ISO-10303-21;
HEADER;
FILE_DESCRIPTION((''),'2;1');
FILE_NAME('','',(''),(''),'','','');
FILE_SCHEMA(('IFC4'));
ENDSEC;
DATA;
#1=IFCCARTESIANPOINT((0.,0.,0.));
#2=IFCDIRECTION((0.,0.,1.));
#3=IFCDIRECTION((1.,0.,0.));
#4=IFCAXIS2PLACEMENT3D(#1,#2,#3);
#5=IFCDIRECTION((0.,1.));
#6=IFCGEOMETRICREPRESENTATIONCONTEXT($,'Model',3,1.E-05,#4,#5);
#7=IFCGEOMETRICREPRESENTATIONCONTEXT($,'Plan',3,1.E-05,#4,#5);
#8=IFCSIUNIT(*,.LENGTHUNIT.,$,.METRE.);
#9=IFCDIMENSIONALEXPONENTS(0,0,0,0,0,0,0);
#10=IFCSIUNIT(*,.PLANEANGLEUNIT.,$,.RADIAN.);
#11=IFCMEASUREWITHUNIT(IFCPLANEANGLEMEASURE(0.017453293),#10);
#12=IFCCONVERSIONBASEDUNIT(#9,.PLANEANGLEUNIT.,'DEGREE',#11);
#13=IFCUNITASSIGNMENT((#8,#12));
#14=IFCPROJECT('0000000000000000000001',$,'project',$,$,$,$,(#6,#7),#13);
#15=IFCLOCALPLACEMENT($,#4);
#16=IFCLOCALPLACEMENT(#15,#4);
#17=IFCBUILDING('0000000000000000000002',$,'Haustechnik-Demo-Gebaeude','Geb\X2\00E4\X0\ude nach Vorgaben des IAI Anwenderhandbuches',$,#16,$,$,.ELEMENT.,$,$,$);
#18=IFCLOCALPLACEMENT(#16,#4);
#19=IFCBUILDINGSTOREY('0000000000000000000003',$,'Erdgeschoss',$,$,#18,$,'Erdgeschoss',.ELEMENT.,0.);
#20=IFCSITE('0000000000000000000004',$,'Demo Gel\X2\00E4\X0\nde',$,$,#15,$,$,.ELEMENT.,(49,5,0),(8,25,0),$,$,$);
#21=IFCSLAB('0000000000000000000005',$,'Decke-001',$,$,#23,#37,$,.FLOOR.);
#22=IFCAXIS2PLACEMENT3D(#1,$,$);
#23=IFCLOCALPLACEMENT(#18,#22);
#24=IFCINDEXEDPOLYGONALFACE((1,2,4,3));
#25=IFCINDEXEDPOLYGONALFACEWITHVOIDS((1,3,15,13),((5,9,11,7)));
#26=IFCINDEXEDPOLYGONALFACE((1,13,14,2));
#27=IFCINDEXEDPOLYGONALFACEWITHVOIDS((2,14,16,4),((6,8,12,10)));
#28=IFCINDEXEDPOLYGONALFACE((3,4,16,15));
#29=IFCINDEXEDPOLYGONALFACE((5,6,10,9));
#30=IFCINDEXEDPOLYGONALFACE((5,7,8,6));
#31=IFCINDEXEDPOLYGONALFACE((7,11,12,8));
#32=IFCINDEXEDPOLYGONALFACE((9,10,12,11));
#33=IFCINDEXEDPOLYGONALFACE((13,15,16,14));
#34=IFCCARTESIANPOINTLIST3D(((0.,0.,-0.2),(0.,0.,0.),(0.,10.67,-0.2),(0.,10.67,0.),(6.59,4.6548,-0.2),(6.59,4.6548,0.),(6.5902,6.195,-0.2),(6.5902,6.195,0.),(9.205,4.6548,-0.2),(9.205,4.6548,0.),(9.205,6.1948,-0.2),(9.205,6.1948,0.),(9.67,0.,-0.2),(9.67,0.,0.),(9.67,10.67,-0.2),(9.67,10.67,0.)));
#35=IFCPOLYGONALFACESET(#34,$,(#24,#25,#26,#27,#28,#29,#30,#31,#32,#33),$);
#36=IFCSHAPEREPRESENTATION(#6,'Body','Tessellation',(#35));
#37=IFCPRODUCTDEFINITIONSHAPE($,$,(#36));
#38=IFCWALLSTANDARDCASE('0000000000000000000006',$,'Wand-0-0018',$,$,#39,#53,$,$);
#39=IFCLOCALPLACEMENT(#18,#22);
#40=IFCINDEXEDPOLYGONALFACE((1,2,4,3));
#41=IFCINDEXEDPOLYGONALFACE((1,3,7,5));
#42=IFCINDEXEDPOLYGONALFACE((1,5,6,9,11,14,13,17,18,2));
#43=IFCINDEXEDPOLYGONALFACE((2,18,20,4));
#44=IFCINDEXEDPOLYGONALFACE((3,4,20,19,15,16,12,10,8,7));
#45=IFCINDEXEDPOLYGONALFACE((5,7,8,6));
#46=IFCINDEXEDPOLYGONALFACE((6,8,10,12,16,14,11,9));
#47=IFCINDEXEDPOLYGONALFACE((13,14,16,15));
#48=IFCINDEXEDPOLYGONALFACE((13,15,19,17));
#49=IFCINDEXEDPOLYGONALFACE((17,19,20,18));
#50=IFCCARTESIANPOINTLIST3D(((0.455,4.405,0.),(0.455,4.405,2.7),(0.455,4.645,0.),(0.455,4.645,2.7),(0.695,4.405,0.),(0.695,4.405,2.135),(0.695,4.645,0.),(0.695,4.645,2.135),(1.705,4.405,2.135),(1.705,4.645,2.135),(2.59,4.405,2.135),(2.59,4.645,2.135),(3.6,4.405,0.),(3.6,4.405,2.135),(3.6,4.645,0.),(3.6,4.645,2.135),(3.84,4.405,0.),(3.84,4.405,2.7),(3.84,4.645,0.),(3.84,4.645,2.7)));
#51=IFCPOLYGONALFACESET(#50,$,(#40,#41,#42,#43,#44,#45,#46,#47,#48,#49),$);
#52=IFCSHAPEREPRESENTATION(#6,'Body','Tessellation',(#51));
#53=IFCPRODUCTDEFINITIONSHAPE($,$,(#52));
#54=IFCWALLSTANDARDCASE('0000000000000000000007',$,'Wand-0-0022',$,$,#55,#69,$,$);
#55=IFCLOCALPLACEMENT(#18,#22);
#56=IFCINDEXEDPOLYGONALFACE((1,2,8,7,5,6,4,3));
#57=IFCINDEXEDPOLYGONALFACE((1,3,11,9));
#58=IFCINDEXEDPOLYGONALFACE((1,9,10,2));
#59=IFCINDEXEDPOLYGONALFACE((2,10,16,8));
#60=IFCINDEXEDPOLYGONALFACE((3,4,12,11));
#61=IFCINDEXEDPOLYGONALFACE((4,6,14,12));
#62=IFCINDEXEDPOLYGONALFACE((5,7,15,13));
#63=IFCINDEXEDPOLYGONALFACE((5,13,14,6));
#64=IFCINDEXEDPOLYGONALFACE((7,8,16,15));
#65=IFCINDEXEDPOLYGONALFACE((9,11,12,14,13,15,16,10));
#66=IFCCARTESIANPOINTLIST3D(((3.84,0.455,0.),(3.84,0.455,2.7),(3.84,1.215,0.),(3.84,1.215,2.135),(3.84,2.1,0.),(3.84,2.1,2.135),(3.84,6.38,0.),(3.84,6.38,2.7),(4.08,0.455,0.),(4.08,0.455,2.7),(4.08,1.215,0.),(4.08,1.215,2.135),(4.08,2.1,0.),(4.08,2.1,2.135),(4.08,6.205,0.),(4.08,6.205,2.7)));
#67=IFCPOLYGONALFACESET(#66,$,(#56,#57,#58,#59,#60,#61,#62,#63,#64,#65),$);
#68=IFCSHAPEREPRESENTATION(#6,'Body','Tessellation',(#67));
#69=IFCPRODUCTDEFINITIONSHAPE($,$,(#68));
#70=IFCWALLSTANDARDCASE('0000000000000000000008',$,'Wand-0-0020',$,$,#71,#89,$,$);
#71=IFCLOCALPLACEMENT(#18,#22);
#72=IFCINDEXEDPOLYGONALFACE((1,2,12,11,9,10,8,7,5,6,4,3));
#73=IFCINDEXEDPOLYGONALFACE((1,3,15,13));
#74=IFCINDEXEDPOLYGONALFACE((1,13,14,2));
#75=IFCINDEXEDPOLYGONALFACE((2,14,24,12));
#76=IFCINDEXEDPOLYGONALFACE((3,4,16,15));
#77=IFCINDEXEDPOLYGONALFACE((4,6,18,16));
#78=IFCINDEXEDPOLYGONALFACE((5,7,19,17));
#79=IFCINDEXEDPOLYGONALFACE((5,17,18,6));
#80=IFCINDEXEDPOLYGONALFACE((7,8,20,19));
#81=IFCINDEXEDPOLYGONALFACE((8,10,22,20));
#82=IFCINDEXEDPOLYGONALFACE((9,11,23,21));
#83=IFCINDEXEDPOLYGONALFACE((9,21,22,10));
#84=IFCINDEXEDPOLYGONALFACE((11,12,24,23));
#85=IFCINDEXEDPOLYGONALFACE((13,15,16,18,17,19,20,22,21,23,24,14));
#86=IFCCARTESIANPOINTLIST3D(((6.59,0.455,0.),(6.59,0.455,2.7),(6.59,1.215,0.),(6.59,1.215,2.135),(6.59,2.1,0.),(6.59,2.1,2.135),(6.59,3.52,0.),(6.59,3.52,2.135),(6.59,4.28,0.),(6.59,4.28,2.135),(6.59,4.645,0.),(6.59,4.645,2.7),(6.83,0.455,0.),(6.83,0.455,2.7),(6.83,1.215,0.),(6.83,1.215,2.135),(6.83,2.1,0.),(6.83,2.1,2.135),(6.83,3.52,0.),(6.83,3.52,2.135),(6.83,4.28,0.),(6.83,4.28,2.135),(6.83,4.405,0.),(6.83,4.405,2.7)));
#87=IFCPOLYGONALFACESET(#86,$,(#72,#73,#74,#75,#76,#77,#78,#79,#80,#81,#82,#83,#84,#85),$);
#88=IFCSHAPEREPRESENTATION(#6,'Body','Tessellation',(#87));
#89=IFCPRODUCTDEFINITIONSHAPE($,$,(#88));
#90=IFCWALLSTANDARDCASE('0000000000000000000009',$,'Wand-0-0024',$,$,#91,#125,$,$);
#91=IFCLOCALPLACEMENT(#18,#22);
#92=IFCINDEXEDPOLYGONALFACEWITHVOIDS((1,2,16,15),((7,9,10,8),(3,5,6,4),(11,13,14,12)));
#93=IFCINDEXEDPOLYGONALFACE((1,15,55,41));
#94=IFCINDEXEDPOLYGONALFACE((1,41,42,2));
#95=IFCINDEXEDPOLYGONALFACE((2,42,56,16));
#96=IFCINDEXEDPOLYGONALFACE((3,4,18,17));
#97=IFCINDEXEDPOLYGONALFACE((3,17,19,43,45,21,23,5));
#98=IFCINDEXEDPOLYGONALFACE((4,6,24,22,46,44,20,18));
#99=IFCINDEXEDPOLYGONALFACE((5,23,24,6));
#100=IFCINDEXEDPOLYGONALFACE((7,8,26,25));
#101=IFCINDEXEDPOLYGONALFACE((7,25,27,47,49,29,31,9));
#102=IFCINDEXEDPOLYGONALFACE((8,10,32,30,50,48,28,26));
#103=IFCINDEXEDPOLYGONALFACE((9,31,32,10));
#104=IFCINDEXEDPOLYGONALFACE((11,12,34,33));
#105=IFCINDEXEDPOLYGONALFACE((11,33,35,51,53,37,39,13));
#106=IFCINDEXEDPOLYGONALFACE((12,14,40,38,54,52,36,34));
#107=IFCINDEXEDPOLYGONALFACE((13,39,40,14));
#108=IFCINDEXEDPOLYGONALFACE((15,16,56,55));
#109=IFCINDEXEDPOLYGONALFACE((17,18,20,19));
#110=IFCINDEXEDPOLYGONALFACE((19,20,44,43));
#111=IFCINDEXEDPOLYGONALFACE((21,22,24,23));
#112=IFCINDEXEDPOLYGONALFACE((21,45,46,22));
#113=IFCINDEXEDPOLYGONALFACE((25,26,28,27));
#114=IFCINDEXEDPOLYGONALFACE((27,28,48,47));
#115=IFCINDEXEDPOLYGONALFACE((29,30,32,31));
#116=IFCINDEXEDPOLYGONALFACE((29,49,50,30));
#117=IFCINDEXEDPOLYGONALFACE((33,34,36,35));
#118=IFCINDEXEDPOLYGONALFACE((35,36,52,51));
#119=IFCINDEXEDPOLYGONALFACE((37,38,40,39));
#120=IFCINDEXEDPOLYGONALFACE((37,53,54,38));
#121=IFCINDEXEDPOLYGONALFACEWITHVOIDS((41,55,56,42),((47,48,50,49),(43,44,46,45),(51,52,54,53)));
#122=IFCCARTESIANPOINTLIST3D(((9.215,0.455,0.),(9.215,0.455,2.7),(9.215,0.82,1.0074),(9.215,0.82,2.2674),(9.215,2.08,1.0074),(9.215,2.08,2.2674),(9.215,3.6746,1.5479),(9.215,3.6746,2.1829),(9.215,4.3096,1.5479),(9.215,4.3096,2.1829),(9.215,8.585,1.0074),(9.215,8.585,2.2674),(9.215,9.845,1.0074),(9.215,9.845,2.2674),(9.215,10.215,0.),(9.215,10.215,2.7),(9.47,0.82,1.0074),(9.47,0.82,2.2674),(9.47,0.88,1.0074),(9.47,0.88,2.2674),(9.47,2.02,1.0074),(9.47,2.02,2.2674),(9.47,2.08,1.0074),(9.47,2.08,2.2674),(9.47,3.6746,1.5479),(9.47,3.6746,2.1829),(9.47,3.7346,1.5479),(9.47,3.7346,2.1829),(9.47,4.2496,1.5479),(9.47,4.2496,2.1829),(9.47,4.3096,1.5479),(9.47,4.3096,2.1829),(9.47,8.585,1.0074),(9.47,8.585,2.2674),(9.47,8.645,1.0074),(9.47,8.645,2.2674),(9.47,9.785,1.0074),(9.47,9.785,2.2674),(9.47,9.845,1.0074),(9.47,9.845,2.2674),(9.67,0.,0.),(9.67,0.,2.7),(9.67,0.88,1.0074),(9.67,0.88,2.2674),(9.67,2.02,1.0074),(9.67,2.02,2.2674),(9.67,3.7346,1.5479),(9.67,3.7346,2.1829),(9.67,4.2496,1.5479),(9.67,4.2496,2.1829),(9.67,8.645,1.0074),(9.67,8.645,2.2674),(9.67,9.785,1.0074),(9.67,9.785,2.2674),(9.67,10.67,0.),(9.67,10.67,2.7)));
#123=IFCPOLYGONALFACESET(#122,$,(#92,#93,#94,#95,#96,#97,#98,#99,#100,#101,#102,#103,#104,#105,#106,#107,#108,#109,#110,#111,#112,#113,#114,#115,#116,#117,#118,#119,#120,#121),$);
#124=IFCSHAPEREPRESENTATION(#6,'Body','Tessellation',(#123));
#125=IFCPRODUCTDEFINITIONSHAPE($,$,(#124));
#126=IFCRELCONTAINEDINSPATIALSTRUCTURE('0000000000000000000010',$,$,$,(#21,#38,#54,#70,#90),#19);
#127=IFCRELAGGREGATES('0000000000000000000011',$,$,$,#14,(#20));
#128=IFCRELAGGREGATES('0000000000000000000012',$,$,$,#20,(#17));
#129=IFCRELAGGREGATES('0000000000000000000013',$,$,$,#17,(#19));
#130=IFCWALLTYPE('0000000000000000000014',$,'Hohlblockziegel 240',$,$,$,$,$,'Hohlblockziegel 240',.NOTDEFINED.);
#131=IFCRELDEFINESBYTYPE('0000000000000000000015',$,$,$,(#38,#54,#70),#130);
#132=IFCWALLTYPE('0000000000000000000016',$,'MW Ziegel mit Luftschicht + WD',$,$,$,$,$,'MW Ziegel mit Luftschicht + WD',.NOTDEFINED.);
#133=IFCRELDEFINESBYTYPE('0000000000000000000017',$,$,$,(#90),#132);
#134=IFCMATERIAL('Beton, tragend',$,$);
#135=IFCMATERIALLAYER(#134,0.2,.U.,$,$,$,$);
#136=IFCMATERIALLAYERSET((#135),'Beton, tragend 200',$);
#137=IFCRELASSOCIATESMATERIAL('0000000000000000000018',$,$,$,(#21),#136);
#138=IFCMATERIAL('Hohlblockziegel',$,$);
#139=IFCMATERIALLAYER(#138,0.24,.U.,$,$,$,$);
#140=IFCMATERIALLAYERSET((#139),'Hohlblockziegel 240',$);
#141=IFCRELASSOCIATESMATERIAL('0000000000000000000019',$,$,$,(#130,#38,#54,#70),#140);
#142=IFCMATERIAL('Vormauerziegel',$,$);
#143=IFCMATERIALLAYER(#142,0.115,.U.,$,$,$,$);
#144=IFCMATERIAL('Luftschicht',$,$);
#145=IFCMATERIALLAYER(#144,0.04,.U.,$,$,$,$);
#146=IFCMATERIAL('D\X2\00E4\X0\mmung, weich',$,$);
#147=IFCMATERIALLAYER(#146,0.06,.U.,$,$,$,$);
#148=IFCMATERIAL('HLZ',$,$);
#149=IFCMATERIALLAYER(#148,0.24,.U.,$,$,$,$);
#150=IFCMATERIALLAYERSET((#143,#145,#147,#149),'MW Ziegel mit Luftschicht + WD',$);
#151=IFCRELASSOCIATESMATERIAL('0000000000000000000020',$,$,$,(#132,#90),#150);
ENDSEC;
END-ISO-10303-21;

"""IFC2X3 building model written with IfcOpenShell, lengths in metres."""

from ifc_helpers import new_model, entity, si_unit, converted_unit, direction, frame, frame_2d, origin_with_axes, place, context, project, spatial, polyline, rectangle, outline, extrude, material, layer, layer_set, layer_usage, type_object, element, save


model = new_model("IFC2X3")

# Units and contexts
model_context = context("Model", 3, precision=1e-05, world=origin_with_axes(), true_north=direction((0.0, 1.0)))
plan_context = context("Plan", 3, precision=1e-05, world=origin_with_axes(), true_north=direction((0.0, 1.0)))
ifc_project = project(units=[si_unit("LENGTHUNIT", "METRE"), converted_unit("PLANEANGLEUNIT", "DEGREE", entity("IfcPlaneAngleMeasure", 0.017453293), si_unit("PLANEANGLEUNIT", "RADIAN"), dimensions=[0, 0, 0, 0, 0, 0, 0])], contexts=[model_context, plan_context])

# Site, building, storey
site_placement = place(None, origin_with_axes())
site = spatial("IfcSite", under=ifc_project, at=site_placement, Name="Demo Gelände", CompositionType="ELEMENT", RefLatitude=(49, 5, 0), RefLongitude=(8, 25, 0))
building_placement = place(site_placement, origin_with_axes())
building = spatial("IfcBuilding", under=site, at=building_placement, Name="Haustechnik-Demo-Gebaeude", Description="Gebäude nach Vorgaben des IAI Anwenderhandbuches", CompositionType="ELEMENT")
storey_placement = place(building_placement, origin_with_axes())
storey = spatial("IfcBuildingStorey", under=building, at=storey_placement, Name="Erdgeschoss", LongName="Erdgeschoss", CompositionType="ELEMENT", Elevation=0.0)

# Slab, opening
ifc_material_1 = material(Name="Beton, tragend")
ifc_layer_1 = layer(ifc_material_1, 0.2, ventilated="UNKNOWN")
ifc_layer_set_1 = layer_set([ifc_layer_1], Name="Beton, tragend 200")
ifc_layer_usage_1 = layer_usage(ifc_layer_set_1, "AXIS3", "NEGATIVE", 0.2)
slab_placement = place(storey_placement, frame((9.67, 10.67, -0.2), z_axis=(0.0, 0.0, 1.0), x_axis=(-1.0, 0.0, 0.0)))
slab = element("IfcSlab", 1, at=slab_placement, inside=storey, material=ifc_layer_usage_1, Name="Decke-001", PredefinedType="FLOOR", context=model_context, shape_type="SweptSolid", body=[
    extrude(outline(polyline([(0.0, 0.0), (9.67, 0.0), (9.67, 10.67), (0.0, 10.67), (0.0, 0.0)])), origin_with_axes(), (0.0, 0.0, 1.0), 0.2),
])
opening_1_placement = place(slab_placement, origin_with_axes())
element("IfcOpeningElement", 2, at=opening_1_placement, cuts=slab, context=model_context, shape_type="SweptSolid", body=[
    extrude(outline(polyline([(0.465, 6.0152), (3.08, 6.0152), (3.0798, 4.475), (0.465, 4.4752), (0.465, 6.0152)])), origin_with_axes(), (0.0, 0.0, 1.0), 0.2),
])

# Wall, openings
ifc_material_2 = material(Name="Hohlblockziegel")
ifc_layer_2 = layer(ifc_material_2, 0.24, ventilated="UNKNOWN")
ifc_layer_set_2 = layer_set([ifc_layer_2], Name="Hohlblockziegel 240")
ifc_layer_usage_2 = layer_usage(ifc_layer_set_2, "AXIS2", "NEGATIVE", 0.0)
wall_type_1 = type_object("IfcWallType", Name="Hohlblockziegel 240", ElementType="Hohlblockziegel 240", PredefinedType="NOTDEFINED", material=ifc_layer_set_2)
wall_1_placement = place(storey_placement, frame((0.0, 4.645, 0.0), z_axis=(0.0, 0.0, 1.0), x_axis=(1.0, 0.0, 0.0)))
wall_1 = element("IfcWallStandardCase", 3, at=wall_1_placement, inside=storey, type_object=wall_type_1, material=ifc_layer_usage_2, Name="Wand-0-0018", context=model_context, shape_type="SweptSolid", body=[
    extrude(outline(polyline([(0.455, -0.24), (3.84, -0.24), (3.84, 0.0), (0.455, 0.0), (0.455, -0.24)])), origin_with_axes(), (0.0, 0.0, 1.0), 2.7),
])
opening_2_placement = place(wall_1_placement, frame((2.1475, -0.24, 0.0), z_axis=(0.0, 0.0, 1.0), x_axis=(1.0, 0.0, 0.0)))
element("IfcOpeningElement", 4, at=opening_2_placement, cuts=wall_1, ObjectType="Opening", context=model_context, shape_type="SweptSolid", body=[
    extrude(outline(polyline([(-0.4425, 0.0), (0.4425, 0.0), (0.4425, 2.135), (-0.4425, 2.135), (-0.4425, 0.0)])), frame((0.0, 0.0, 0.0), z_axis=(0.0, 1.0, 0.0), x_axis=(-1.0, 0.0, 0.0)), (0.0, 0.0, 1.0), 0.24),
])
opening_3_placement = place(wall_1_placement, frame((1.2, -0.24, 0.0), z_axis=(0.0, 0.0, 1.0), x_axis=(1.0, 0.0, 0.0)))
element("IfcOpeningElement", 5, at=opening_3_placement, cuts=wall_1, ObjectType="Opening", context=model_context, shape_type="SweptSolid", body=[
    extrude(outline(polyline([(-0.505, 0.0), (0.505, 0.0), (0.505, 2.135), (-0.505, 2.135), (-0.505, 0.0)])), frame((0.0, 0.0, 0.0), z_axis=(0.0, 1.0, 0.0), x_axis=(-1.0, 0.0, 0.0)), (0.0, 0.0, 1.0), 0.24),
])
opening_4_placement = place(wall_1_placement, frame((3.095, -0.24, 0.0), z_axis=(0.0, 0.0, 1.0), x_axis=(1.0, 0.0, 0.0)))
element("IfcOpeningElement", 6, at=opening_4_placement, cuts=wall_1, ObjectType="Opening", context=model_context, shape_type="SweptSolid", body=[
    extrude(outline(polyline([(-0.505, 0.0), (0.505, 0.0), (0.505, 2.135), (-0.505, 2.135), (-0.505, 0.0)])), frame((0.0, 0.0, 0.0), z_axis=(0.0, 1.0, 0.0), x_axis=(-1.0, 0.0, 0.0)), (0.0, 0.0, 1.0), 0.24),
])

# Wall, opening
ifc_layer_usage_3 = layer_usage(ifc_layer_set_2, "AXIS2", "NEGATIVE", 0.0)
wall_2_placement = place(storey_placement, frame((3.84, 0.0, 0.0), z_axis=(0.0, 0.0, 1.0), x_axis=(0.0, 1.0, 0.0)))
wall_2 = element("IfcWallStandardCase", 7, at=wall_2_placement, inside=storey, type_object=wall_type_1, material=ifc_layer_usage_3, Name="Wand-0-0022", context=model_context, shape_type="SweptSolid", body=[
    extrude(outline(polyline([(0.455, -0.24), (6.205, -0.24), (6.38, 0.0), (0.455, 0.0), (0.455, -0.24)])), origin_with_axes(), (0.0, 0.0, 1.0), 2.7),
])
opening_5_placement = place(wall_2_placement, frame((1.6575, -0.24, 0.0), z_axis=(0.0, 0.0, 1.0), x_axis=(1.0, 0.0, 0.0)))
element("IfcOpeningElement", 8, at=opening_5_placement, cuts=wall_2, ObjectType="Opening", context=model_context, shape_type="SweptSolid", body=[
    extrude(rectangle(XDim=0.885, YDim=2.135, at=frame_2d((0.0, 1.0675), x_axis=(-1.0, 0.0))), frame((0.0, 0.0, 0.0), z_axis=(0.0, 1.0, 0.0), x_axis=(-1.0, 0.0, 0.0)), (0.0, 0.0, 1.0), 0.24),
])

# Wall, openings
ifc_layer_usage_4 = layer_usage(ifc_layer_set_2, "AXIS2", "POSITIVE", 0.0)
wall_3_placement = place(storey_placement, frame((6.83, 0.0, 0.0), z_axis=(0.0, 0.0, 1.0), x_axis=(0.0, 1.0, 0.0)))
wall_3 = element("IfcWallStandardCase", 9, at=wall_3_placement, inside=storey, type_object=wall_type_1, material=ifc_layer_usage_4, Name="Wand-0-0020", context=model_context, shape_type="SweptSolid", body=[
    extrude(outline(polyline([(0.455, 0.0), (4.405, 0.0), (4.645, 0.24), (0.455, 0.24), (0.455, 0.0)])), origin_with_axes(), (0.0, 0.0, 1.0), 2.7),
])
opening_6_placement = place(wall_3_placement, frame((3.9, 0.0, 0.0), z_axis=(0.0, 0.0, 1.0), x_axis=(1.0, 0.0, 0.0)))
element("IfcOpeningElement", 10, at=opening_6_placement, cuts=wall_3, ObjectType="Opening", context=model_context, shape_type="SweptSolid", body=[
    extrude(rectangle(XDim=0.76, YDim=2.135, at=frame_2d((0.0, 1.0675), x_axis=(-1.0, 0.0))), frame((0.0, 0.0, 0.0), z_axis=(0.0, 1.0, 0.0), x_axis=(-1.0, 0.0, 0.0)), (0.0, 0.0, 1.0), 0.24),
])
opening_7_placement = place(wall_3_placement, frame((1.6575, 0.0, 0.0), z_axis=(0.0, 0.0, 1.0), x_axis=(1.0, 0.0, 0.0)))
element("IfcOpeningElement", 11, at=opening_7_placement, cuts=wall_3, ObjectType="Opening", context=model_context, shape_type="SweptSolid", body=[
    extrude(rectangle(XDim=0.885, YDim=2.135, at=frame_2d((0.0, 1.0675), x_axis=(-1.0, 0.0))), frame((0.0, 0.0, 0.0), z_axis=(0.0, 1.0, 0.0), x_axis=(-1.0, 0.0, 0.0)), (0.0, 0.0, 1.0), 0.24),
])

# Wall, openings
ifc_material_3 = material(Name="Vormauerziegel")
ifc_layer_3 = layer(ifc_material_3, 0.115, ventilated="UNKNOWN")
ifc_material_4 = material(Name="Luftschicht")
ifc_layer_4 = layer(ifc_material_4, 0.04, ventilated="UNKNOWN")
ifc_material_5 = material(Name="Dämmung, weich")
ifc_layer_5 = layer(ifc_material_5, 0.06, ventilated="UNKNOWN")
ifc_material_6 = material(Name="HLZ")
ifc_layer_6 = layer(ifc_material_6, 0.24, ventilated="UNKNOWN")
ifc_layer_set_3 = layer_set([ifc_layer_3, ifc_layer_4, ifc_layer_5, ifc_layer_6], Name="MW Ziegel mit Luftschicht + WD")
ifc_layer_usage_5 = layer_usage(ifc_layer_set_3, "AXIS2", "POSITIVE", 0.0)
wall_type_2 = type_object("IfcWallType", Name="MW Ziegel mit Luftschicht + WD", ElementType="MW Ziegel mit Luftschicht + WD", PredefinedType="NOTDEFINED", material=ifc_layer_set_3)
wall_4_placement = place(storey_placement, frame((9.67, 0.0, 0.0), z_axis=(0.0, 0.0, 1.0), x_axis=(0.0, 1.0, 0.0)))
wall_4 = element("IfcWallStandardCase", 12, at=wall_4_placement, inside=storey, type_object=wall_type_2, material=ifc_layer_usage_5, Name="Wand-0-0024", context=model_context, shape_type="SweptSolid", body=[
    extrude(outline(polyline([(0.0, 0.0), (10.67, 0.0), (10.215, 0.455), (0.455, 0.455), (0.0, 0.0)])), origin_with_axes(), (0.0, 0.0, 1.0), 2.7),
])
opening_8_placement = place(wall_4_placement, frame((3.9921, 0.0, 1.5479), z_axis=(0.0, 0.0, 1.0), x_axis=(1.0, 0.0, 0.0)))
element("IfcOpeningElement", 13, at=opening_8_placement, cuts=wall_4, ObjectType="Opening", context=model_context, shape_type="SweptSolid", body=[
    extrude(outline(polyline([(-0.2575, 0.0), (0.2575, 0.0), (0.2575, 0.2), (0.3175, 0.2), (0.3175, 0.455), (-0.3175, 0.455), (-0.3175, 0.2), (-0.2575, 0.2), (-0.2575, 0.0)])), origin_with_axes(), (0.0, 0.0, 1.0), 0.635),
])
opening_9_placement = place(wall_4_placement, frame((9.215, 0.0, 1.0074), z_axis=(0.0, 0.0, 1.0), x_axis=(1.0, 0.0, 0.0)))
element("IfcOpeningElement", 14, at=opening_9_placement, cuts=wall_4, ObjectType="Opening", context=model_context, shape_type="SweptSolid", body=[
    extrude(outline(polyline([(-0.57, 0.0), (0.57, 0.0), (0.57, 0.2), (0.63, 0.2), (0.63, 0.455), (-0.63, 0.455), (-0.63, 0.2), (-0.57, 0.2), (-0.57, 0.0)])), origin_with_axes(), (0.0, 0.0, 1.0), 1.26),
])
opening_10_placement = place(wall_4_placement, frame((1.45, 0.0, 1.0074), z_axis=(0.0, 0.0, 1.0), x_axis=(1.0, 0.0, 0.0)))
element("IfcOpeningElement", 15, at=opening_10_placement, cuts=wall_4, ObjectType="Opening", context=model_context, shape_type="SweptSolid", body=[
    extrude(outline(polyline([(-0.57, 0.0), (0.57, 0.0), (0.57, 0.2), (0.63, 0.2), (0.63, 0.455), (-0.63, 0.455), (-0.63, 0.2), (-0.57, 0.2), (-0.57, 0.0)])), origin_with_axes(), (0.0, 0.0, 1.0), 1.26),
])

save(model, "model.ifc")
